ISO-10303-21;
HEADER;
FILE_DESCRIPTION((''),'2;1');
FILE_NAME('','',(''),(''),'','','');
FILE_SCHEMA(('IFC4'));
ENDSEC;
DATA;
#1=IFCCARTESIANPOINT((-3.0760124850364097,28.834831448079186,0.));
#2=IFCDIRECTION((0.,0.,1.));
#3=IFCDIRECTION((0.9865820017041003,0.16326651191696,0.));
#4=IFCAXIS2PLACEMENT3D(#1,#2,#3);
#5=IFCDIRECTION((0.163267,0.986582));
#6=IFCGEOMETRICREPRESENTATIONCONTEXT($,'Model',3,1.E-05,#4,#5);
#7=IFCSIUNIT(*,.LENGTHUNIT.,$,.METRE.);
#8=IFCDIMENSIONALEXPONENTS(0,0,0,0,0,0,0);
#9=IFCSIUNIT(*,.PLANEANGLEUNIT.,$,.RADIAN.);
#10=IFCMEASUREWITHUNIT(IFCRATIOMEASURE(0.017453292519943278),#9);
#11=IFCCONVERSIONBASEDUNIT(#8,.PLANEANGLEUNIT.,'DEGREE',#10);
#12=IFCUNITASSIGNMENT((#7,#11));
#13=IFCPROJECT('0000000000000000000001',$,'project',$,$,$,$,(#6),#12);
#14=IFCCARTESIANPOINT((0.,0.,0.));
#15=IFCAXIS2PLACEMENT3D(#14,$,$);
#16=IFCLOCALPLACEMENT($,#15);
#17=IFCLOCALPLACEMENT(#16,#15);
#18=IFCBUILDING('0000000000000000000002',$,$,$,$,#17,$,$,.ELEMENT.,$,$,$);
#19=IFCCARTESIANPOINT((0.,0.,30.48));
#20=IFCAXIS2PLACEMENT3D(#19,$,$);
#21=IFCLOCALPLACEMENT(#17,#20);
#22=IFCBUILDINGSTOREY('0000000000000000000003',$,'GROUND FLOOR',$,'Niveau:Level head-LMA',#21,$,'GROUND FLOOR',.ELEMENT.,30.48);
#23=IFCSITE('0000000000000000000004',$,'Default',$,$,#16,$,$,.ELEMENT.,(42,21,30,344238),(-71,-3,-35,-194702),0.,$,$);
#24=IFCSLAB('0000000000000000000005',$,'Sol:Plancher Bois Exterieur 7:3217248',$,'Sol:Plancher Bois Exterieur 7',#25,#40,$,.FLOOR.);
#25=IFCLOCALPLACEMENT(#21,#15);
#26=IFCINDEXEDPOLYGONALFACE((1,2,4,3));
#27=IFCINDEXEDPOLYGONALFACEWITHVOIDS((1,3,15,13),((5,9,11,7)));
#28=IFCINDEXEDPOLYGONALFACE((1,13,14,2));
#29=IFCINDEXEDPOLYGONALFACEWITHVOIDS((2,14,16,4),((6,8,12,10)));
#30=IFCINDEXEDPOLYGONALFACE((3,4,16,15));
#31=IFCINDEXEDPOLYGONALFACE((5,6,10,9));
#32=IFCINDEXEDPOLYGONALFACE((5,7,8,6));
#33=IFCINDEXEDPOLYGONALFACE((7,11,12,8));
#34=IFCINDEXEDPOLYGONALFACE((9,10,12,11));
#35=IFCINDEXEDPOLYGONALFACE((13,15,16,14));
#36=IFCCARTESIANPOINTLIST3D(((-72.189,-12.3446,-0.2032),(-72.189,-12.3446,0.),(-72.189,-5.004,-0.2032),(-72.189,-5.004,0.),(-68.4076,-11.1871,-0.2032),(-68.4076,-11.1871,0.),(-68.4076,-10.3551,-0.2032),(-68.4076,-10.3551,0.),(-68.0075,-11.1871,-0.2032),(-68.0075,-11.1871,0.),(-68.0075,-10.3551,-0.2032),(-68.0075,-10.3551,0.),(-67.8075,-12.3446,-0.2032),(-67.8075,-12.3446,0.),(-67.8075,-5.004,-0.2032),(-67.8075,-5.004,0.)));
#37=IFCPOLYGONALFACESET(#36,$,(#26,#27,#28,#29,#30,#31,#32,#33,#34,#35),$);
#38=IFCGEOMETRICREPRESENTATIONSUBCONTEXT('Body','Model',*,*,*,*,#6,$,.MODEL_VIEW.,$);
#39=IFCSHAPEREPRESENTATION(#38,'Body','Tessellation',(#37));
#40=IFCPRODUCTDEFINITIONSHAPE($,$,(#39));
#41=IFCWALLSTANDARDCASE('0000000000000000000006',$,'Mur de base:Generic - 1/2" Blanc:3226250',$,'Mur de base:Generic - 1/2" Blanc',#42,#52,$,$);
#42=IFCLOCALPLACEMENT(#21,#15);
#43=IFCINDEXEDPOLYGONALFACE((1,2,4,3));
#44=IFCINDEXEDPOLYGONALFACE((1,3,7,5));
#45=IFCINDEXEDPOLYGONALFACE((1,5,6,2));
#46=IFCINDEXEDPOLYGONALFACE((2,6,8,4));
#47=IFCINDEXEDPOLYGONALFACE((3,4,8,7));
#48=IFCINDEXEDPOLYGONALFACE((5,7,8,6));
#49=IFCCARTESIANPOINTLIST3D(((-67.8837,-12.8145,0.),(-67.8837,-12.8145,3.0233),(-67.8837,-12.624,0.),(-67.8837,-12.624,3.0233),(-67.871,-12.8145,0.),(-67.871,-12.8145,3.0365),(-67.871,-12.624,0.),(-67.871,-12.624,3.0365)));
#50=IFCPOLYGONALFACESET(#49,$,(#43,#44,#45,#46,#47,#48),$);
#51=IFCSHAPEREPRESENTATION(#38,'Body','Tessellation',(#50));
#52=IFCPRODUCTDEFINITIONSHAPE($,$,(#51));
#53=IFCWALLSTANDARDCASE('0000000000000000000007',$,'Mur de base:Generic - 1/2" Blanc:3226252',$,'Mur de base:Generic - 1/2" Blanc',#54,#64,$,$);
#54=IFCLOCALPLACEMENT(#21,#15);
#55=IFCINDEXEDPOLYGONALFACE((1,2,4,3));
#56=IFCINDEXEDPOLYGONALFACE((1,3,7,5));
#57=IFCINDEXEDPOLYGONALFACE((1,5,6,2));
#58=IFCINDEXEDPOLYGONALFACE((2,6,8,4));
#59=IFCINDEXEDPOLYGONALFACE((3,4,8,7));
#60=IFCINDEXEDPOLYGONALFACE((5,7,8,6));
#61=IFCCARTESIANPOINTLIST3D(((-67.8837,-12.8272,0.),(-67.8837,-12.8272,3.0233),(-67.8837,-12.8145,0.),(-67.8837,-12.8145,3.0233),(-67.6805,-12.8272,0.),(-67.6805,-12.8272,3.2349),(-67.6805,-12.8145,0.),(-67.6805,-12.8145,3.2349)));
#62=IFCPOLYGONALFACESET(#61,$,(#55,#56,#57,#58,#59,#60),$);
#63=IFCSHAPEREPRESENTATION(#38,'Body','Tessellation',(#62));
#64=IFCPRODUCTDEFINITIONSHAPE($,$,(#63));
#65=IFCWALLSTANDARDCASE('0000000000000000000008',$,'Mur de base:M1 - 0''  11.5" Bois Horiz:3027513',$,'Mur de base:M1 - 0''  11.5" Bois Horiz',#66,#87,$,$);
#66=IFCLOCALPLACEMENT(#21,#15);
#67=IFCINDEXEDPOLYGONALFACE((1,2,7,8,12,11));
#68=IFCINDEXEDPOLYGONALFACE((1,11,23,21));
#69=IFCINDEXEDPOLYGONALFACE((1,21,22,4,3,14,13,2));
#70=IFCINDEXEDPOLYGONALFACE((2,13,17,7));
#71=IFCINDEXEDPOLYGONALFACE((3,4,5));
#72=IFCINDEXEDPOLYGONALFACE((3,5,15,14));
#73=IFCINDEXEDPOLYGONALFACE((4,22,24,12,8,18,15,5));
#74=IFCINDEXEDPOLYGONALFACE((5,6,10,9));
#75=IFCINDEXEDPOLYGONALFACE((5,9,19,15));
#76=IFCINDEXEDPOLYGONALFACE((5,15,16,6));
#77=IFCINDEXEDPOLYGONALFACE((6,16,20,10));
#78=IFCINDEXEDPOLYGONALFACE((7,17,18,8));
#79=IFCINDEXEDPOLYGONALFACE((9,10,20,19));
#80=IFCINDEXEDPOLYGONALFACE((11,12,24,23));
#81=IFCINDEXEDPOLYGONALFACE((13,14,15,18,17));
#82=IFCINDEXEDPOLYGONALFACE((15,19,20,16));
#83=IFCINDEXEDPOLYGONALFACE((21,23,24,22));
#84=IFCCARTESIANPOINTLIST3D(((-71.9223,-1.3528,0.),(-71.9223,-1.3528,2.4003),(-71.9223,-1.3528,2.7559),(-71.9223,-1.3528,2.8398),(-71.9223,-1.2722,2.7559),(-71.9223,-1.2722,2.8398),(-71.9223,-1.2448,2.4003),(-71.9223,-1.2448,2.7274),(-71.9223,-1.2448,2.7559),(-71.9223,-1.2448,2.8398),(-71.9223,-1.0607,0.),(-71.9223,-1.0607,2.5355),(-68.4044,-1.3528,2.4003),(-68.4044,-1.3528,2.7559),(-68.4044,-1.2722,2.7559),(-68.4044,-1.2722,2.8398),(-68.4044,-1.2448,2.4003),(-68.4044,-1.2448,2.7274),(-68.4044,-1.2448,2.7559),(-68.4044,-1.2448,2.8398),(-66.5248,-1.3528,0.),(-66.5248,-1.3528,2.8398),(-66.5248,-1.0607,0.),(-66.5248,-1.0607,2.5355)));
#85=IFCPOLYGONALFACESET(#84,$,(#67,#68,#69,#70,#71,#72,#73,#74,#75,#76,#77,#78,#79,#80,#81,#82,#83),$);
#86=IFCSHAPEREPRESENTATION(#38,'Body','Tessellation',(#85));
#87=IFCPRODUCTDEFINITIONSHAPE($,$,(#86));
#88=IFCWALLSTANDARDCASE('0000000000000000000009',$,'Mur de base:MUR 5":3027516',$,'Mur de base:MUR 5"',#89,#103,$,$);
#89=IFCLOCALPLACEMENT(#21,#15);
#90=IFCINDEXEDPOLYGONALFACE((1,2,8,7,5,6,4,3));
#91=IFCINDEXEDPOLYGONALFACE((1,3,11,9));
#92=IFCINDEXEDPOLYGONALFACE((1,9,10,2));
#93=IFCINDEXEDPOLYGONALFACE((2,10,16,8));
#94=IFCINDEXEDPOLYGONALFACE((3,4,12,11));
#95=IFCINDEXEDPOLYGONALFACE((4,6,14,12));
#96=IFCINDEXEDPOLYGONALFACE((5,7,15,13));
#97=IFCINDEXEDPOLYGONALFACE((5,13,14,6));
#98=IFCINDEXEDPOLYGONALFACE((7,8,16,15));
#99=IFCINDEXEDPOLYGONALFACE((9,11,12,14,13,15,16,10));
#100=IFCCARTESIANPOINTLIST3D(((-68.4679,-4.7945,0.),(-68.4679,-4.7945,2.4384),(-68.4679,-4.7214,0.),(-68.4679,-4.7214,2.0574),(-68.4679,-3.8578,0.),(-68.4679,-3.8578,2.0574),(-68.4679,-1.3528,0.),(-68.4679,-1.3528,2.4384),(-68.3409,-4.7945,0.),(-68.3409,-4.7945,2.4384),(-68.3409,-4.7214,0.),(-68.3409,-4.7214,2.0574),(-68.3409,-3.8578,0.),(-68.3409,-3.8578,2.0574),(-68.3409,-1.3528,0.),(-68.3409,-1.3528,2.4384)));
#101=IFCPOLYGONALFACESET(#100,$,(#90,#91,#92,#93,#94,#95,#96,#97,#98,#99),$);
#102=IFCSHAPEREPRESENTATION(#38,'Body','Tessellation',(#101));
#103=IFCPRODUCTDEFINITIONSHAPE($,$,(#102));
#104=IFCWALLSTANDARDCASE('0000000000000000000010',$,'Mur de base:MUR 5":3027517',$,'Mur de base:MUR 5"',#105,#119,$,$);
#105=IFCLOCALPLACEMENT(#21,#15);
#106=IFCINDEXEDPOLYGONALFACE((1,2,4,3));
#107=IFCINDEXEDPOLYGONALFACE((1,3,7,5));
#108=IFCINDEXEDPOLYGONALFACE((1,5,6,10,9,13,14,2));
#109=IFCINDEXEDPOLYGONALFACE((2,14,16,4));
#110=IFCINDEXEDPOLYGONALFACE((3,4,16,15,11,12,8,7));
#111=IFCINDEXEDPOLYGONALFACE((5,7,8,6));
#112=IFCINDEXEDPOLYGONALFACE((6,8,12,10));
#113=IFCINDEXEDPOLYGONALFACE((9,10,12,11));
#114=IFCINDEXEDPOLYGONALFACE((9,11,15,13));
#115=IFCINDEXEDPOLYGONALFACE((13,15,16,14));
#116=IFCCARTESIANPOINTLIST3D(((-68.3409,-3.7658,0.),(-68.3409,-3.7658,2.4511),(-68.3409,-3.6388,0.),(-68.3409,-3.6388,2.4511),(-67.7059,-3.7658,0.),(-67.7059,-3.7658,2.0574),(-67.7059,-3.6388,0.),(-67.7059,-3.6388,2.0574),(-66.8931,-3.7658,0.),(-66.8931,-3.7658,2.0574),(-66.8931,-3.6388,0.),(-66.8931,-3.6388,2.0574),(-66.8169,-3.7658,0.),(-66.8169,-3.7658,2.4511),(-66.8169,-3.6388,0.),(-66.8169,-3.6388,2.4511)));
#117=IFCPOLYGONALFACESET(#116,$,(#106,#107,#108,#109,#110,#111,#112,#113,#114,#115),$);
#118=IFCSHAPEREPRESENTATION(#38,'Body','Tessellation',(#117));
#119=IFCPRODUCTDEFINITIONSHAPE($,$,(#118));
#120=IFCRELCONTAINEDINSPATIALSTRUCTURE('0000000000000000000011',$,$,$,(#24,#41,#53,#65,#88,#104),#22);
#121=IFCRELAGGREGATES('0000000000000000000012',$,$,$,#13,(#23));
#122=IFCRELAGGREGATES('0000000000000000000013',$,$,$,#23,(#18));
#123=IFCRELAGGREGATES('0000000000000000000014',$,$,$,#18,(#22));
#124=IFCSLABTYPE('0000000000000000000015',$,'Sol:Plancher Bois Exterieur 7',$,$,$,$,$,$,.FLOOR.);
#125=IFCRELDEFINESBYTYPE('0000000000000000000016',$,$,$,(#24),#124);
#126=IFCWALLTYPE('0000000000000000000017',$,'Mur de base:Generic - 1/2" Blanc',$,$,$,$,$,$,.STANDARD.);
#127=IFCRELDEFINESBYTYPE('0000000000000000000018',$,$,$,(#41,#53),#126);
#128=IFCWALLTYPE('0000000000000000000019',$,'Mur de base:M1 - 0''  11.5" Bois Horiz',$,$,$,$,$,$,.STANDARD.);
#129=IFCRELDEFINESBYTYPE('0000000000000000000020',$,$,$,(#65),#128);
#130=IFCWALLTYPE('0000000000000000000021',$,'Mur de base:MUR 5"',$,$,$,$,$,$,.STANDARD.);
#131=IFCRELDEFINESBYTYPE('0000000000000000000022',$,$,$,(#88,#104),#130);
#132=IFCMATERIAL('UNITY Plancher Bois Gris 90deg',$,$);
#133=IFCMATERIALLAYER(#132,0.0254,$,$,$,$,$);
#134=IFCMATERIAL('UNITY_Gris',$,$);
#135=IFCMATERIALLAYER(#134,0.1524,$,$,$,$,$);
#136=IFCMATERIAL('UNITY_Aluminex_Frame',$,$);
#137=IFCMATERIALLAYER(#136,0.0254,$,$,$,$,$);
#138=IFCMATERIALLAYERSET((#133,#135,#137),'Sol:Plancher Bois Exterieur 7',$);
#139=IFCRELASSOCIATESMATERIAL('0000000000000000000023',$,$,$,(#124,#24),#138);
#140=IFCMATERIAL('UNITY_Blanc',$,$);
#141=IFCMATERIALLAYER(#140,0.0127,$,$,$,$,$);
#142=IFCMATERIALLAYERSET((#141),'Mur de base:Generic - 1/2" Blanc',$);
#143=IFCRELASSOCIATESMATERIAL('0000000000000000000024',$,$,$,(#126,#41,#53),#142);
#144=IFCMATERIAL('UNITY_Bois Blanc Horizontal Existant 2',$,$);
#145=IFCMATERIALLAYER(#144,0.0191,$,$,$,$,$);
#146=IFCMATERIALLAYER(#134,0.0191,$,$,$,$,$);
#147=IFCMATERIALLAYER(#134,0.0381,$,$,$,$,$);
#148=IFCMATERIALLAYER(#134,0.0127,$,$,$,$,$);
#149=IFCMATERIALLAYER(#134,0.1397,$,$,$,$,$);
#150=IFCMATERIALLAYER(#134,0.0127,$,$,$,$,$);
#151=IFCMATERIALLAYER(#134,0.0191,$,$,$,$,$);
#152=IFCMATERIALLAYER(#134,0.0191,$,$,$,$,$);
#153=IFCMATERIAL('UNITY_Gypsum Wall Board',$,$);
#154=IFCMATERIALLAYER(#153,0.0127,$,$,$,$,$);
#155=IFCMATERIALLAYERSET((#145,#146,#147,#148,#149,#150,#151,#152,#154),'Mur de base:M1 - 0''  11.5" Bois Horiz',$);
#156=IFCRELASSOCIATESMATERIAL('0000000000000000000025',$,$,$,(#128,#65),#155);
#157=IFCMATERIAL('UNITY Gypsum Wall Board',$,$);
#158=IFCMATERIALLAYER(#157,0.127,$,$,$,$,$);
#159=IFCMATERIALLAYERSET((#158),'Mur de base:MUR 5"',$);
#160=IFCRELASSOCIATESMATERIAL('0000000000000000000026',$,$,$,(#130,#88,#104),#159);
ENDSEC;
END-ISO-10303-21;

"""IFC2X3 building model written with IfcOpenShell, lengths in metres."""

from ifc_helpers import new_model, entity, si_unit, converted_unit, direction, frame, frame_2d, origin, origin_2d_with_axis, place, context, subcontext, project, spatial, polyline, rectangle, extrude, clip, bounded_halfspace, material, layer, layer_set, layer_usage, type_object, element, save


model = new_model("IFC2X3")

# Units and contexts
model_context = context("Model", 3, precision=1e-05, world=frame((-3.0760124850364097, 28.834831448079186, 0.0), z_axis=(0.0, 0.0, 1.0), x_axis=(0.9865820017041003, 0.16326651191696, 0.0)), true_north=direction((0.163267, 0.986582)))
body_context = subcontext(model_context, "Body", "Model", "MODEL_VIEW")
ifc_project = project(units=[si_unit("LENGTHUNIT", "METRE"), converted_unit("PLANEANGLEUNIT", "DEGREE", entity("IfcRatioMeasure", 0.017453292519943278), si_unit("PLANEANGLEUNIT", "RADIAN"), dimensions=[0, 0, 0, 0, 0, 0, 0])], contexts=[model_context])

# Site, building, storey
site_placement = place(None, origin())
site = spatial("IfcSite", under=ifc_project, at=site_placement, Name="Default", CompositionType="ELEMENT", RefLatitude=(42, 21, 30, 344238), RefLongitude=(-71, -3, -35, -194702), RefElevation=0.0)
building_placement = place(site_placement, origin())
building = spatial("IfcBuilding", under=site, at=building_placement, CompositionType="ELEMENT")
storey_placement = place(building_placement, frame((0.0, 0.0, 30.48)))
storey = spatial("IfcBuildingStorey", under=building, at=storey_placement, Name="GROUND FLOOR", ObjectType="Niveau:Level head-LMA", LongName="GROUND FLOOR", CompositionType="ELEMENT", Elevation=30.48)

# Shared definitions
ifc_material_1 = material(Name="UNITY_Aluminex_Frame")

# Slab, opening
ifc_material_2 = material(Name="UNITY Plancher Bois Gris 90deg")
ifc_layer_1 = layer(ifc_material_2, 0.0254)
ifc_material_3 = material(Name="UNITY_Gris")
ifc_layer_2 = layer(ifc_material_3, 0.1524)
ifc_layer_3 = layer(ifc_material_1, 0.0254)
ifc_layer_set_1 = layer_set([ifc_layer_1, ifc_layer_2, ifc_layer_3], Name="Sol:Plancher Bois Exterieur 7")
ifc_layer_usage_1 = layer_usage(ifc_layer_set_1, "AXIS3", "POSITIVE", 0.0)
slab_type = type_object("IfcSlabType", Name="Sol:Plancher Bois Exterieur 7", PredefinedType="FLOOR", material=ifc_layer_set_1)
slab_placement = place(storey_placement, frame((-72.189, -12.3446, -0.2032)))
slab = element("IfcSlab", 1, at=slab_placement, inside=storey, type_object=slab_type, material=ifc_layer_usage_1, Name="Sol:Plancher Bois Exterieur 7:3217248", ObjectType="Sol:Plancher Bois Exterieur 7", PredefinedType="FLOOR", context=body_context, shape_type="SweptSolid", body=[
    extrude(rectangle(XDim=7.3406, YDim=4.3815, at=frame_2d((0.0, 0.0), x_axis=(0.0, 1.0))), frame((2.1908, 3.6703, 0.2032), z_axis=(0.0, 0.0, -1.0), x_axis=(-1.0, 0.0, 0.0)), (0.0, 0.0, 1.0), 0.2032),
])
opening_1_placement = place(slab_placement, frame((3.9815, 1.5735, 0.2032)))
element("IfcOpeningElement", 2, at=opening_1_placement, cuts=slab, ObjectType="Opening", context=body_context, shape_type="SweptSolid", body=[
    extrude(rectangle(XDim=0.832, YDim=0.4001, at=origin_2d_with_axis()), frame((0.0, 0.0, 0.0), z_axis=(0.0, 0.0, -1.0), x_axis=(0.0, 1.0, 0.0)), (0.0, 0.0, 1.0), 0.2032),
])

# Walls
ifc_material_4 = material(Name="UNITY_Blanc")
ifc_layer_4 = layer(ifc_material_4, 0.0127)
ifc_layer_set_2 = layer_set([ifc_layer_4], Name="Mur de base:Generic - 1/2\" Blanc")
ifc_layer_usage_2 = layer_usage(ifc_layer_set_2, "AXIS2", "POSITIVE", -0.0063)
wall_type_1 = type_object("IfcWallType", Name="Mur de base:Generic - 1/2\" Blanc", PredefinedType="STANDARD", material=ifc_layer_set_2)
wall_1_placement = place(storey_placement, frame((-67.8773, -12.624, 0.0), z_axis=(0.0, 0.0, 1.0), x_axis=(0.0, -1.0, 0.0)))
element("IfcWallStandardCase", 3, at=wall_1_placement, inside=storey, type_object=wall_type_1, material=ifc_layer_usage_2, Name="Mur de base:Generic - 1/2\" Blanc:3226250", ObjectType="Mur de base:Generic - 1/2\" Blanc", context=body_context, shape_type="Clipping", body=[
    clip(extrude(rectangle(XDim=0.1905, YDim=0.0127, at=frame_2d((0.0952, 0.0), x_axis=(-1.0, 0.0))), origin(), (0.0, 0.0, 1.0), 3.0365), bounded_halfspace(frame((0.0, -0.0063, 3.0233), z_axis=(0.0, -0.721387, 0.692532), x_axis=(1.0, 0.0, 0.0)), False, frame((0.0, -0.0063, 3.0233)), polyline([(0.0, 0.0), (0.1905, 0.0), (0.1905, 0.0127), (0.0, 0.0127), (0.0, 0.0)]))),
])
ifc_layer_usage_3 = layer_usage(ifc_layer_set_2, "AXIS2", "POSITIVE", -0.0063)
wall_2_placement = place(storey_placement, frame((-67.8837, -12.8209, 0.0)))
element("IfcWallStandardCase", 4, at=wall_2_placement, inside=storey, type_object=wall_type_1, material=ifc_layer_usage_3, Name="Mur de base:Generic - 1/2\" Blanc:3226252", ObjectType="Mur de base:Generic - 1/2\" Blanc", context=body_context, shape_type="Clipping", body=[
    clip(extrude(rectangle(XDim=0.2032, YDim=0.0127, at=frame_2d((0.1016, 0.0), x_axis=(-1.0, 0.0))), origin(), (0.0, 0.0, 1.0), 3.2349), bounded_halfspace(frame((0.0, -0.0063, 3.0233), z_axis=(-0.721387, 0.0, 0.692532), x_axis=(0.0, -1.0, 0.0)), False, frame((0.0, -0.0063, 3.0233)), polyline([(0.0, 0.0), (0.2032, 0.0), (0.2032, 0.0127), (0.0127, 0.0127), (0.0, 0.0127), (0.0, 0.0)]))),
])

# Walls, openings
ifc_material_5 = material(Name="UNITY_Bois Blanc Horizontal Existant 2")
ifc_layer_5 = layer(ifc_material_5, 0.0191)
ifc_layer_6 = layer(ifc_material_3, 0.0191)
ifc_layer_7 = layer(ifc_material_3, 0.0381)
ifc_layer_8 = layer(ifc_material_3, 0.0127)
ifc_layer_9 = layer(ifc_material_3, 0.1397)
ifc_layer_10 = layer(ifc_material_3, 0.0127)
ifc_layer_11 = layer(ifc_material_3, 0.0191)
ifc_layer_12 = layer(ifc_material_3, 0.0191)
ifc_material_6 = material(Name="UNITY_Gypsum Wall Board")
ifc_layer_13 = layer(ifc_material_6, 0.0127)
ifc_layer_set_3 = layer_set([ifc_layer_5, ifc_layer_6, ifc_layer_7, ifc_layer_8, ifc_layer_9, ifc_layer_10, ifc_layer_11, ifc_layer_12, ifc_layer_13], Name="Mur de base:M1 - 0'  11.5\" Bois Horiz")
wall_type_2 = type_object("IfcWallType", Name="Mur de base:M1 - 0'  11.5\" Bois Horiz", PredefinedType="STANDARD", material=ifc_layer_set_3)
ifc_layer_usage_4 = layer_usage(ifc_layer_set_3, "AXIS2", "NEGATIVE", 0.1461)
wall_3_placement = place(storey_placement, frame((-71.9223, -1.2067, 0.0)))
wall_3 = element("IfcWallStandardCase", 5, at=wall_3_placement, inside=storey, type_object=wall_type_2, material=ifc_layer_usage_4, Name="Mur de base:M1 - 0'  11.5\" Bois Horiz:3027513", ObjectType="Mur de base:M1 - 0'  11.5\" Bois Horiz", context=body_context, shape_type="Clipping", body=[
    clip(extrude(rectangle(XDim=5.3975, YDim=0.2921, at=frame_2d((2.6988, 0.0), x_axis=(-1.0, 0.0))), origin(), (0.0, 0.0, 1.0), 2.8398), bounded_halfspace(frame((0.0, -0.146, 2.8398), z_axis=(0.0, 0.721387, 0.692532), x_axis=(-1.0, 0.0, 0.0)), False, frame((0.0, -0.146, 2.8398)), polyline([(0.0, 0.0), (3.4544, 0.0), (3.5814, 0.0), (5.1054, 0.0), (5.3975, 0.0), (5.3975, 0.2921), (0.0, 0.2921), (0.0, 0.108), (3.5179, 0.108), (3.5179, 0.0805), (0.0, 0.0805), (0.0, 0.0)]))),
])
opening_2_placement = place(storey_placement, frame((-71.9223, -1.2067, 0.0)))
element("IfcOpeningElement", 6, at=opening_2_placement, cuts=wall_3, ObjectType="Opening", context=body_context, shape_type="SweptSolid", body=[
    extrude(rectangle(XDim=0.108, YDim=3.5179, at=frame_2d((0.0, 0.0), x_axis=(1.0, 0.0))), frame((1.7589, -0.0921, 2.4003), z_axis=(0.0, 0.0, 1.0), x_axis=(0.0, 1.0, 0.0)), (0.0, 0.0, 1.0), 0.3556),
])
ifc_material_7 = material(Name="UNITY Gypsum Wall Board")
ifc_layer_14 = layer(ifc_material_7, 0.127)
ifc_layer_set_4 = layer_set([ifc_layer_14], Name="Mur de base:MUR 5\"")
ifc_layer_usage_5 = layer_usage(ifc_layer_set_4, "AXIS2", "NEGATIVE", 0.0635)
wall_type_3 = type_object("IfcWallType", Name="Mur de base:MUR 5\"", PredefinedType="STANDARD", material=ifc_layer_set_4)
wall_4_placement = place(storey_placement, frame((-68.4044, -4.7945, 0.0), z_axis=(0.0, 0.0, 1.0), x_axis=(0.0, 1.0, 0.0)))
wall_4 = element("IfcWallStandardCase", 7, at=wall_4_placement, inside=storey, type_object=wall_type_3, material=ifc_layer_usage_5, Name="Mur de base:MUR 5\":3027516", ObjectType="Mur de base:MUR 5\"", context=body_context, shape_type="SweptSolid", body=[
    extrude(rectangle(XDim=3.4417, YDim=0.127, at=frame_2d((1.7208, 0.0), x_axis=(-1.0, 0.0))), origin(), (0.0, 0.0, 1.0), 2.4384),
])
opening_3_placement = place(wall_4_placement, frame((4.7945, -68.4044, 0.0), z_axis=(0.0, 0.0, 1.0), x_axis=(0.0, -1.0, 0.0)))
element("IfcOpeningElement", 8, at=opening_3_placement, cuts=wall_4, ObjectType="Opening", context=body_context, shape_type="SweptSolid", body=[
    extrude(rectangle(XDim=2.0574, YDim=0.8636, at=frame_2d((0.0, 0.0), x_axis=(1.0, 0.0))), frame((-66.8169, -4.2896, 1.0287), z_axis=(-1.0, 0.0, 0.0), x_axis=(0.0, 0.0, 1.0)), (0.0, 0.0, 1.0), 3.048),
])
ifc_layer_usage_6 = layer_usage(ifc_layer_set_4, "AXIS2", "POSITIVE", -0.0635)
wall_5_placement = place(storey_placement, frame((-68.3409, -3.7023, 0.0)))
wall_5 = element("IfcWallStandardCase", 9, at=wall_5_placement, inside=storey, type_object=wall_type_3, material=ifc_layer_usage_6, Name="Mur de base:MUR 5\":3027517", ObjectType="Mur de base:MUR 5\"", context=body_context, shape_type="SweptSolid", body=[
    extrude(rectangle(XDim=1.524, YDim=0.127, at=frame_2d((0.762, 0.0), x_axis=(-1.0, 0.0))), origin(), (0.0, 0.0, 1.0), 2.4511),
])
opening_4_placement = place(wall_5_placement, frame((68.3409, 3.7023, 0.0)))
element("IfcOpeningElement", 10, at=opening_4_placement, cuts=wall_5, ObjectType="Opening", context=body_context, shape_type="SweptSolid", body=[
    extrude(rectangle(XDim=2.0574, YDim=0.8128, at=frame_2d((0.0, 0.0), x_axis=(0.0, 1.0))), frame((-67.2995, -5.2898, 1.0287), z_axis=(0.0, 1.0, 0.0), x_axis=(-1.0, 0.0, 0.0)), (0.0, 0.0, 1.0), 3.048),
])

save(model, "model.ifc")
